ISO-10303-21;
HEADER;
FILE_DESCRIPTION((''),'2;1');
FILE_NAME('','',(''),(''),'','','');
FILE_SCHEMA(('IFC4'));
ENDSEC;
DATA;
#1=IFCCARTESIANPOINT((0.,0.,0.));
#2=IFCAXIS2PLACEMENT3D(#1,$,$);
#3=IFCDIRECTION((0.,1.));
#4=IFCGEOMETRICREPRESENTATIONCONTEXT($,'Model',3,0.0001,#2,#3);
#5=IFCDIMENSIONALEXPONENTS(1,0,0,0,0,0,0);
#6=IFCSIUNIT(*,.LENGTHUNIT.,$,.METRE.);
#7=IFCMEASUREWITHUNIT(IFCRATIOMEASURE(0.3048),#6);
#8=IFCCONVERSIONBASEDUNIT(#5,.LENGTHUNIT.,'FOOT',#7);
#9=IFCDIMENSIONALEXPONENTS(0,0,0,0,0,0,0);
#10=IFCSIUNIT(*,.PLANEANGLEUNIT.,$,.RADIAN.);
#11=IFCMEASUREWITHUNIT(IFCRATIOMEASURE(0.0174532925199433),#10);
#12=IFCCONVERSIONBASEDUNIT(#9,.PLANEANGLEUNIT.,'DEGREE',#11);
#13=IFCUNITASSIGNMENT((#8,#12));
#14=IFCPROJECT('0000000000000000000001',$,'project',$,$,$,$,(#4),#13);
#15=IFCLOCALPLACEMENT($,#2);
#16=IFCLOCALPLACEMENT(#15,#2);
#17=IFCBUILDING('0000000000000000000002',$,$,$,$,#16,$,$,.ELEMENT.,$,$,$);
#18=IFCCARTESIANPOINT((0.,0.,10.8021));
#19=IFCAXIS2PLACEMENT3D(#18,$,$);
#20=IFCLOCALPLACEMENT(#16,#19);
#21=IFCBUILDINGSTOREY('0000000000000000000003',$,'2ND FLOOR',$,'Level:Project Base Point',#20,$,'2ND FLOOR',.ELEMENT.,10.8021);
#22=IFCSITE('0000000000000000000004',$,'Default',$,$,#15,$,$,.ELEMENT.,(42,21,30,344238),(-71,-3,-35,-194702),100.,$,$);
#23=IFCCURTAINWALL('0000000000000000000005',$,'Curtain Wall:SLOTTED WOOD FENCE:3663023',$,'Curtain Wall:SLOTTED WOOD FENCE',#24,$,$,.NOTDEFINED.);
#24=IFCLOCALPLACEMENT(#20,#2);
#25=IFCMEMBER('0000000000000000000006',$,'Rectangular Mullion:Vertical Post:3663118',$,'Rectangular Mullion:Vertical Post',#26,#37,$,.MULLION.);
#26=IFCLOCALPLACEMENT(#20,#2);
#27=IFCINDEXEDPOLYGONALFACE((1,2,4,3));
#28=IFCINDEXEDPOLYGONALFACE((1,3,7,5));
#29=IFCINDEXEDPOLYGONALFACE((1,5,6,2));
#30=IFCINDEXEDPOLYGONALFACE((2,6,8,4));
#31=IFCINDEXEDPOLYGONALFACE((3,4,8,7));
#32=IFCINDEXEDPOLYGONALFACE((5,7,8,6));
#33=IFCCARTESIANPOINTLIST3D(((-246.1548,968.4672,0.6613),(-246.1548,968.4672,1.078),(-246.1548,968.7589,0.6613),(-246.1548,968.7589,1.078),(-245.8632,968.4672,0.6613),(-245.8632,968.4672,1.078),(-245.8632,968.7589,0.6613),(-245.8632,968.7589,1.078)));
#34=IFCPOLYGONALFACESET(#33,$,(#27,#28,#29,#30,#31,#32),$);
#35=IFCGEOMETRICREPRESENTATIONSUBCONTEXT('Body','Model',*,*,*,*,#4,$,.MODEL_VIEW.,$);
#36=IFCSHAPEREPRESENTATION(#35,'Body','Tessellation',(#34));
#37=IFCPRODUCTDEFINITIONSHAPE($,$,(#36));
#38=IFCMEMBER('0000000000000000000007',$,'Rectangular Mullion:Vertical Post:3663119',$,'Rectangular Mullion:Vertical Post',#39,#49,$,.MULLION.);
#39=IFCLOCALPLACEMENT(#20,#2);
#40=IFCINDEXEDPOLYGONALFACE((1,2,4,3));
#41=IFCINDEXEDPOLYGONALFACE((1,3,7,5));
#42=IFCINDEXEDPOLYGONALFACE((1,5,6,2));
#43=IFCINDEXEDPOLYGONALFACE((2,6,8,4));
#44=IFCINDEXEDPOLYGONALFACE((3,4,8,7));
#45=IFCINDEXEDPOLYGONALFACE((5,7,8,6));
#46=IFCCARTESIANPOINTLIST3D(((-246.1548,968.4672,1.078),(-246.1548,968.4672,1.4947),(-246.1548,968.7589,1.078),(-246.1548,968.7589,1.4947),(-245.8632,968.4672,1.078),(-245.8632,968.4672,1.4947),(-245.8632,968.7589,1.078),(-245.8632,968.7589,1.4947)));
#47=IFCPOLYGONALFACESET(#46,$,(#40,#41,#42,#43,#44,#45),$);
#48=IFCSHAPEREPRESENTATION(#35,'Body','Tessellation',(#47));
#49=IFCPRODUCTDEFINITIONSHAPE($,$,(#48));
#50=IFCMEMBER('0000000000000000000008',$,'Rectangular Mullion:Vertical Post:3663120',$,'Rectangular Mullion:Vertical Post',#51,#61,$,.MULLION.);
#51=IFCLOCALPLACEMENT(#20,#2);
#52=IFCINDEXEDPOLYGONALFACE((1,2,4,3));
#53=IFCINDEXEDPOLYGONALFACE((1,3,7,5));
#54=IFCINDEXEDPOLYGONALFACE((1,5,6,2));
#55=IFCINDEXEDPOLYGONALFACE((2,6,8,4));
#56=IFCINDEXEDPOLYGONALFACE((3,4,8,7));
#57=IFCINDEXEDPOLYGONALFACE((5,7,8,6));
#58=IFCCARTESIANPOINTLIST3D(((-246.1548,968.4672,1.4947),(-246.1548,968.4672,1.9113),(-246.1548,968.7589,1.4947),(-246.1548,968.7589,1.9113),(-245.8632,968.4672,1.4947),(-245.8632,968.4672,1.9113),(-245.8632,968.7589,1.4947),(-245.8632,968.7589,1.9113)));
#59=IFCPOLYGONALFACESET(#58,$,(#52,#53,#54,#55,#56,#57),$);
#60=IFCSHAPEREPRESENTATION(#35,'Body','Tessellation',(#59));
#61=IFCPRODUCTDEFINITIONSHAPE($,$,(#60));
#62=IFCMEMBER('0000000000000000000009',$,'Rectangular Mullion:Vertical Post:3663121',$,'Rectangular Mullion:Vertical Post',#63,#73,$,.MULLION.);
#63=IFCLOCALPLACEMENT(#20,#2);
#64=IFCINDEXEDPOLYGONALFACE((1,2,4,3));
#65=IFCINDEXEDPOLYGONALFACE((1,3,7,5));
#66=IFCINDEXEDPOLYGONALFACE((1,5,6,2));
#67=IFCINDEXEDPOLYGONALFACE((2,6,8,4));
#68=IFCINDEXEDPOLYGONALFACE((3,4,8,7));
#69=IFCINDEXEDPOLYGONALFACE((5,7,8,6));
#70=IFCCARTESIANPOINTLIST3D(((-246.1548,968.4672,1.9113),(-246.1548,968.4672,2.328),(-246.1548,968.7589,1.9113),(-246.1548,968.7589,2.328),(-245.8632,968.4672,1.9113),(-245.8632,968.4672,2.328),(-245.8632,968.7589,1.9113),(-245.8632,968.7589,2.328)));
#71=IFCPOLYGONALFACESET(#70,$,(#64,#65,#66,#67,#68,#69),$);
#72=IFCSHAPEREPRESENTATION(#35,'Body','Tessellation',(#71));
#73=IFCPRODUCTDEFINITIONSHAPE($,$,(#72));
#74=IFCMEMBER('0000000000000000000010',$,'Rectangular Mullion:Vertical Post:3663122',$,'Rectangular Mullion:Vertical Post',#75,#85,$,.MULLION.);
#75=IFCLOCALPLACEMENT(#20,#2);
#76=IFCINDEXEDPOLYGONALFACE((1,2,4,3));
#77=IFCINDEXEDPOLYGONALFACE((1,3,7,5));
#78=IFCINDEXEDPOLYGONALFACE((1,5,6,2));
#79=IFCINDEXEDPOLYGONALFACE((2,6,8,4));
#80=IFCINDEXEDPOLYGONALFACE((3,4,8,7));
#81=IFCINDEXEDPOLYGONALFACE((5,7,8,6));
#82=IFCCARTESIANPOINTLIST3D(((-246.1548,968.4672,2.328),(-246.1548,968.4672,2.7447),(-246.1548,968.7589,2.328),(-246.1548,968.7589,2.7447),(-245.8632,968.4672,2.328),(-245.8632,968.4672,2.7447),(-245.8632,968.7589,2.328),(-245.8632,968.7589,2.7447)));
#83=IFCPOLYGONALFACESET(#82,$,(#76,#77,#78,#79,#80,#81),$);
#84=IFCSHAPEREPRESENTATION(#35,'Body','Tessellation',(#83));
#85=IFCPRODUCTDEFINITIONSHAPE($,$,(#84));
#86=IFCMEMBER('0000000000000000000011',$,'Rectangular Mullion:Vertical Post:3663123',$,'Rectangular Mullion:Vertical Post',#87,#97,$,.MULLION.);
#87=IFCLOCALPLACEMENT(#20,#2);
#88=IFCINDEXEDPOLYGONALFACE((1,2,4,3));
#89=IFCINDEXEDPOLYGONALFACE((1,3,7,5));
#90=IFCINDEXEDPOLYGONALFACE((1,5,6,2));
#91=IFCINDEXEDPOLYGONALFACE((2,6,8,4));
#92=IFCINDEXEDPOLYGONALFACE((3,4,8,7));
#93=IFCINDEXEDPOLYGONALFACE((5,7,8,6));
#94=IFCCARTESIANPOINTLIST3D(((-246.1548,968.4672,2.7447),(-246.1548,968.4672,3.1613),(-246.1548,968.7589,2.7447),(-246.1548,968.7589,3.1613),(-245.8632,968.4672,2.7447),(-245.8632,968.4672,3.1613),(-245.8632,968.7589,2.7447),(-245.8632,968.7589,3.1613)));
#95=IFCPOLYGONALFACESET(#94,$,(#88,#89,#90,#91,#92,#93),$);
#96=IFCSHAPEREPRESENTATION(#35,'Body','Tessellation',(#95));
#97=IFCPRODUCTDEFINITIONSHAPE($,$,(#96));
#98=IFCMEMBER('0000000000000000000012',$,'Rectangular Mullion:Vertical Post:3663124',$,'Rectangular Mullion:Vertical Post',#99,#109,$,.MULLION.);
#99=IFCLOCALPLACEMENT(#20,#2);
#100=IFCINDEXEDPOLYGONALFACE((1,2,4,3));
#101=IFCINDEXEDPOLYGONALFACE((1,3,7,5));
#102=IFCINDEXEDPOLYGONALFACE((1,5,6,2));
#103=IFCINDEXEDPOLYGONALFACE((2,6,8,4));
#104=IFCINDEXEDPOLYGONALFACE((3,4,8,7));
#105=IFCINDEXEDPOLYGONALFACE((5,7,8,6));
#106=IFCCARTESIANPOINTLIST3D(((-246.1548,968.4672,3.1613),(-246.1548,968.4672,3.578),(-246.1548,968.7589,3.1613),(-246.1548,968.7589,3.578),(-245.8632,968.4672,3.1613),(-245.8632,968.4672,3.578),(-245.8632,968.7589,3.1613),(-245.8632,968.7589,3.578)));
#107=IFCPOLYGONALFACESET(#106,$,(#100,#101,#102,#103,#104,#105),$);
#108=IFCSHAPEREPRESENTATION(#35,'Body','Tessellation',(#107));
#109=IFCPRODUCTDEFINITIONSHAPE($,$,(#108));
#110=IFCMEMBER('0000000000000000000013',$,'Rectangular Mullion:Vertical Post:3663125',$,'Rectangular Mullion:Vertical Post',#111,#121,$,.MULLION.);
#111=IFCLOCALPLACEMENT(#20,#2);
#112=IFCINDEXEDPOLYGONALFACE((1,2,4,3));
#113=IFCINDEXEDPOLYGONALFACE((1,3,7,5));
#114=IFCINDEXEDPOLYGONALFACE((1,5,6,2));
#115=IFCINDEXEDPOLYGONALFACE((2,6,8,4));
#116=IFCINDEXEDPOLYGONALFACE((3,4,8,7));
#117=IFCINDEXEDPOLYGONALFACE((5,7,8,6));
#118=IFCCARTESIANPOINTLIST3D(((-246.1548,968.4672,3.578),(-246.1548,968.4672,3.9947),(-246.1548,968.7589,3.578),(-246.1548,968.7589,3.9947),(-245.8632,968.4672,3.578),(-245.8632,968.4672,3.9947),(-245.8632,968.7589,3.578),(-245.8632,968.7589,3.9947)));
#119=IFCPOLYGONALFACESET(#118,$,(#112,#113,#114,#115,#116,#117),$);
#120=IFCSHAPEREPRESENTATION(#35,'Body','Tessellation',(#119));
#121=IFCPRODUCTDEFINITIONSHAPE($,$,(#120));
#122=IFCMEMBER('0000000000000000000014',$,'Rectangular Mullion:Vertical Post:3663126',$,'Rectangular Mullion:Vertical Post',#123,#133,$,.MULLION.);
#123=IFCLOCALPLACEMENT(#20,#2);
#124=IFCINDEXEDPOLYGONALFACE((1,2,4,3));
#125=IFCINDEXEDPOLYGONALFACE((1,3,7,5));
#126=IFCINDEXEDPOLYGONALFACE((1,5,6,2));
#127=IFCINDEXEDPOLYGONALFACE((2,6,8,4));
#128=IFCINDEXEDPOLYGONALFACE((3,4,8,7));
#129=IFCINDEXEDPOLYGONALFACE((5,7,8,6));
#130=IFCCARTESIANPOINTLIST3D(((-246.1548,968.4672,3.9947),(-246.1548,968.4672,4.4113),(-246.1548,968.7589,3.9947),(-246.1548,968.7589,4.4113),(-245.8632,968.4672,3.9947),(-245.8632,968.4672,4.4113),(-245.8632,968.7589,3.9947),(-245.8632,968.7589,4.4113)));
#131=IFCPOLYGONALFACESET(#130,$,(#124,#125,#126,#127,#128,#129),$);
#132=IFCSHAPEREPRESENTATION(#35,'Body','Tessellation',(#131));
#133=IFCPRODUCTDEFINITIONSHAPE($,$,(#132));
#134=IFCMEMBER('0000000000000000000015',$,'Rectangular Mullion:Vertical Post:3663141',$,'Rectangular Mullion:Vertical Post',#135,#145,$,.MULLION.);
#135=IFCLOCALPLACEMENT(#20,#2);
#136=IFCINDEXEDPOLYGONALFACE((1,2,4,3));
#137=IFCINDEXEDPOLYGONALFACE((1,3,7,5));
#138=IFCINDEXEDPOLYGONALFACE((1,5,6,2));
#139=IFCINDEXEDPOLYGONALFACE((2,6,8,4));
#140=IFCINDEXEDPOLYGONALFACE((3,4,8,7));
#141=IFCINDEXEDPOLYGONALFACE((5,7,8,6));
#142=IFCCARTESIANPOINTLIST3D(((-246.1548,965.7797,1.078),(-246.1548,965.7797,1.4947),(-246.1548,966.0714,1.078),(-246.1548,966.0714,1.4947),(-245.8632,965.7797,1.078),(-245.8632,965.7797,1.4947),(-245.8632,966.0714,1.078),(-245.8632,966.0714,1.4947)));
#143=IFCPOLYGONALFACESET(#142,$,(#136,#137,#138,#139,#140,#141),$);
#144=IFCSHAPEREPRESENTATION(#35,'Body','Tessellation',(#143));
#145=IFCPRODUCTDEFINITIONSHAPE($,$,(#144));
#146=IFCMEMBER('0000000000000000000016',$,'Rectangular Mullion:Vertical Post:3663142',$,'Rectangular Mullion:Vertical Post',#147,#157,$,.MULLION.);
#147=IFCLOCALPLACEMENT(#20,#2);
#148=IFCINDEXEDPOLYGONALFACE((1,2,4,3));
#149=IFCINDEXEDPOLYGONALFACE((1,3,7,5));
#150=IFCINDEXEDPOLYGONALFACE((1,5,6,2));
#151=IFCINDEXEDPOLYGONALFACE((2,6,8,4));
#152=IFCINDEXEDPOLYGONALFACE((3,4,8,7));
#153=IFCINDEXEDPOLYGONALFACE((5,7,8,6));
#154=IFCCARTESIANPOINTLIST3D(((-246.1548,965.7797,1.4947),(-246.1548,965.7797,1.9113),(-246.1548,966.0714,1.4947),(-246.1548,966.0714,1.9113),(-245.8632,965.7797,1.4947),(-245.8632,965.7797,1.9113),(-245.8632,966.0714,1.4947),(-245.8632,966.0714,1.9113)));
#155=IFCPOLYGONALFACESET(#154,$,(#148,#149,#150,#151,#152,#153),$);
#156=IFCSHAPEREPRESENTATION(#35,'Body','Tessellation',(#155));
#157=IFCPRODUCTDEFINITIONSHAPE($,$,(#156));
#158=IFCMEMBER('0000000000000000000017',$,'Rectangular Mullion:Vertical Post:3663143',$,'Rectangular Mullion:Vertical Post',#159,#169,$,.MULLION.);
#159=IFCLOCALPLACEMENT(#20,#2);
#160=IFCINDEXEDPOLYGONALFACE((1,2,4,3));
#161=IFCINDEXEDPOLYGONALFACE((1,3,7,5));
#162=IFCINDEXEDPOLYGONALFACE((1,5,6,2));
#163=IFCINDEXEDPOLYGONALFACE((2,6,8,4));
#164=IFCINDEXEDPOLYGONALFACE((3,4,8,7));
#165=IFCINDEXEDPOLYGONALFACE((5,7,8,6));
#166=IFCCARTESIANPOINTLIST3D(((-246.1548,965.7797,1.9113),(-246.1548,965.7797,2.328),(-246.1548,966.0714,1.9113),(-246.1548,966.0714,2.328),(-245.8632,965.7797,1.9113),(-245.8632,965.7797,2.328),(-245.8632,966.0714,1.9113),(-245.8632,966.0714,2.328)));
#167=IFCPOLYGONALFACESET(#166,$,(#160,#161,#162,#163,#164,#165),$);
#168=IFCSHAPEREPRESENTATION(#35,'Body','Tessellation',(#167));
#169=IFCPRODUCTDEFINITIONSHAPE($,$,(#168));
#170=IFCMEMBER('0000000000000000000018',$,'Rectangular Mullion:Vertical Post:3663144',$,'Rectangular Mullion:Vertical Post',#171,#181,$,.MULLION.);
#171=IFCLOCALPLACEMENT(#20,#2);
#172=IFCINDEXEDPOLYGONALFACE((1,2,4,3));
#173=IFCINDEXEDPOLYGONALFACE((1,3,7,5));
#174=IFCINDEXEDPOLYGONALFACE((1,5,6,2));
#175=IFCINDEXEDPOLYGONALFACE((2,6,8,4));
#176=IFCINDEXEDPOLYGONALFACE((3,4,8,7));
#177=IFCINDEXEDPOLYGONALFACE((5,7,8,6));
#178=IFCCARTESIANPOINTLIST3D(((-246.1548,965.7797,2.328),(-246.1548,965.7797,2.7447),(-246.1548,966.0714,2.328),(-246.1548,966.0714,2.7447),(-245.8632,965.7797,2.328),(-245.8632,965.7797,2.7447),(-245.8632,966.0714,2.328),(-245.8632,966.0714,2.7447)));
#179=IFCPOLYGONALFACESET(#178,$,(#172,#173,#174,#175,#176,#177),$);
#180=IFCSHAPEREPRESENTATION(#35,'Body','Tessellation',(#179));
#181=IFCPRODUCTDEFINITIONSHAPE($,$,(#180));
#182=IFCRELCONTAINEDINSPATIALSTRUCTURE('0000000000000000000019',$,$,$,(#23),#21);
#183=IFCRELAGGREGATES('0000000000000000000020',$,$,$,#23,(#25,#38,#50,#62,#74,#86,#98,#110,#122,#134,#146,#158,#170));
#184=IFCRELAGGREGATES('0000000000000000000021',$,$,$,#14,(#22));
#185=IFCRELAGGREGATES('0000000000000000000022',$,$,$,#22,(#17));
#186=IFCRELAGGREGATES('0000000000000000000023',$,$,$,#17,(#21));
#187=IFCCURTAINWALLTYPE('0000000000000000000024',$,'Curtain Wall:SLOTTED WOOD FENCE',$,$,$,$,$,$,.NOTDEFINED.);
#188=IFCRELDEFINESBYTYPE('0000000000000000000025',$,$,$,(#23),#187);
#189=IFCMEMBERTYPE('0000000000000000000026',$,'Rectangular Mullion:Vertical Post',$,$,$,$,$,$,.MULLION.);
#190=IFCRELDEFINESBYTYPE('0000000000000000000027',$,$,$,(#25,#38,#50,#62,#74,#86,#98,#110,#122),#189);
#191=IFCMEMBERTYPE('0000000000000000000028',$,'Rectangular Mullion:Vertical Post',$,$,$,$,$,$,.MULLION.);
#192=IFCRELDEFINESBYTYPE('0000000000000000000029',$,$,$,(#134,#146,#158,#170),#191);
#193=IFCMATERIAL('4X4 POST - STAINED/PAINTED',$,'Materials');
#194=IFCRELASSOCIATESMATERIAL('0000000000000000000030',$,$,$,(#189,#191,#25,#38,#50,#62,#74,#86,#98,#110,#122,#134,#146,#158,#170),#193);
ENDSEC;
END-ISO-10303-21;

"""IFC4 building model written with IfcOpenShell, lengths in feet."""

from ifc_helpers import new_model, entity, si_unit, converted_unit, direction, frame, origin, origin_2d_with_axis, place, context, subcontext, project, spatial, rectangle, extrude, source, transform, mapped, material, material_profile, profile_set, profile_usage, type_object, type_shapes, element, aggregate, save


model = new_model("IFC4")

# Units and contexts
model_context = context("Model", 3, precision=0.0001, world=origin(), true_north=direction((0.0, 1.0)))
body_context = subcontext(model_context, "Body", "Model", "MODEL_VIEW")
ifc_project = project(units=[converted_unit("LENGTHUNIT", "FOOT", entity("IfcRatioMeasure", 0.3048), si_unit("LENGTHUNIT", "METRE"), dimensions=[1, 0, 0, 0, 0, 0, 0]), converted_unit("PLANEANGLEUNIT", "DEGREE", entity("IfcRatioMeasure", 0.0174532925199433), si_unit("PLANEANGLEUNIT", "RADIAN"), dimensions=[0, 0, 0, 0, 0, 0, 0])], contexts=[model_context])

# Site, building, storey
site_placement = place(None, origin())
site = spatial("IfcSite", under=ifc_project, at=site_placement, Name="Default", CompositionType="ELEMENT", RefLatitude=(42, 21, 30, 344238), RefLongitude=(-71, -3, -35, -194702), RefElevation=100.0)
building_placement = place(site_placement, origin())
building = spatial("IfcBuilding", under=site, at=building_placement, CompositionType="ELEMENT")
storey_placement = place(building_placement, frame((0.0, 0.0, 10.8021)))
storey = spatial("IfcBuildingStorey", under=building, at=storey_placement, Name="2ND FLOOR", ObjectType="Level:Project Base Point", LongName="2ND FLOOR", CompositionType="ELEMENT", Elevation=10.8021)

# Curtain wall, members
curtain_wall_type_1 = type_object("IfcCurtainWallType", Name="Curtain Wall:SLOTTED WOOD FENCE", PredefinedType="NOTDEFINED")
curtain_wall_1_placement = place(storey_placement, frame((0.0, 0.0, -10.8021)))
curtain_wall_1 = element("IfcCurtainWall", 1, at=curtain_wall_1_placement, inside=storey, type_object=curtain_wall_type_1, Name="Curtain Wall:SLOTTED WOOD FENCE:3663023", ObjectType="Curtain Wall:SLOTTED WOOD FENCE", PredefinedType="NOTDEFINED")
ifc_material_1 = material(Name="4X4 POST - STAINED/PAINTED", Category="Materials")
ifc_material_profile_1 = material_profile(ifc_material_1, rectangle(XDim=0.2917, YDim=0.2917, at=origin_2d_with_axis()), Name="Vertical Post")
ifc_profile_set_1 = profile_set([ifc_material_profile_1], Name="Vertical Post")
ifc_profile_usage_1 = profile_usage(ifc_profile_set_1)
member_type_1 = type_object("IfcMemberType", Name="Rectangular Mullion:Vertical Post", PredefinedType="MULLION", material=ifc_profile_set_1)
shared_shape_1 = source(origin(), body_context, "Body", "SweptSolid", [
    extrude(rectangle(XDim=0.2917, YDim=0.2917, at=origin_2d_with_axis()), frame((-0.1458, 0.2083, -0.4167), z_axis=(0.0, 0.0, 1.0), x_axis=(0.0, -1.0, 0.0)), (0.0, 0.0, 1.0), 0.4167),
])
type_shapes(member_type_1, [shared_shape_1])
member_1_placement = place(storey_placement, frame((-245.8007, 968.7589, 1.078), z_axis=(0.0, 0.0, 1.0), x_axis=(0.0, 1.0, 0.0)))
member_1 = element("IfcMember", 2, at=member_1_placement, type_object=member_type_1, material=ifc_profile_usage_1, Name="Rectangular Mullion:Vertical Post:3663118", ObjectType="Rectangular Mullion:Vertical Post", PredefinedType="MULLION", context=body_context, shape_type="MappedRepresentation", body=[
    mapped(shared_shape_1, transform((0.0, 0.0, 0.0), scale=1.0)),
])
ifc_profile_usage_2 = profile_usage(ifc_profile_set_1)
member_2_placement = place(storey_placement, frame((-245.8007, 968.7589, 1.4947), z_axis=(0.0, 0.0, 1.0), x_axis=(0.0, 1.0, 0.0)))
member_2 = element("IfcMember", 3, at=member_2_placement, type_object=member_type_1, material=ifc_profile_usage_2, Name="Rectangular Mullion:Vertical Post:3663119", ObjectType="Rectangular Mullion:Vertical Post", PredefinedType="MULLION", context=body_context, shape_type="MappedRepresentation", body=[
    mapped(shared_shape_1, transform((0.0, 0.0, 0.0), scale=1.0)),
])
ifc_profile_usage_3 = profile_usage(ifc_profile_set_1)
member_3_placement = place(storey_placement, frame((-245.8007, 968.7589, 1.9113), z_axis=(0.0, 0.0, 1.0), x_axis=(0.0, 1.0, 0.0)))
member_3 = element("IfcMember", 4, at=member_3_placement, type_object=member_type_1, material=ifc_profile_usage_3, Name="Rectangular Mullion:Vertical Post:3663120", ObjectType="Rectangular Mullion:Vertical Post", PredefinedType="MULLION", context=body_context, shape_type="MappedRepresentation", body=[
    mapped(shared_shape_1, transform((0.0, 0.0, 0.0), scale=1.0)),
])
ifc_profile_usage_4 = profile_usage(ifc_profile_set_1)
member_4_placement = place(storey_placement, frame((-245.8007, 968.7589, 2.328), z_axis=(0.0, 0.0, 1.0), x_axis=(0.0, 1.0, 0.0)))
member_4 = element("IfcMember", 5, at=member_4_placement, type_object=member_type_1, material=ifc_profile_usage_4, Name="Rectangular Mullion:Vertical Post:3663121", ObjectType="Rectangular Mullion:Vertical Post", PredefinedType="MULLION", context=body_context, shape_type="MappedRepresentation", body=[
    mapped(shared_shape_1, transform((0.0, 0.0, 0.0), scale=1.0)),
])
ifc_profile_usage_5 = profile_usage(ifc_profile_set_1)
member_5_placement = place(storey_placement, frame((-245.8007, 968.7589, 2.7447), z_axis=(0.0, 0.0, 1.0), x_axis=(0.0, 1.0, 0.0)))
member_5 = element("IfcMember", 6, at=member_5_placement, type_object=member_type_1, material=ifc_profile_usage_5, Name="Rectangular Mullion:Vertical Post:3663122", ObjectType="Rectangular Mullion:Vertical Post", PredefinedType="MULLION", context=body_context, shape_type="MappedRepresentation", body=[
    mapped(shared_shape_1, transform((0.0, 0.0, 0.0), scale=1.0)),
])
ifc_profile_usage_6 = profile_usage(ifc_profile_set_1)
member_6_placement = place(storey_placement, frame((-245.8007, 968.7589, 3.1613), z_axis=(0.0, 0.0, 1.0), x_axis=(0.0, 1.0, 0.0)))
member_6 = element("IfcMember", 7, at=member_6_placement, type_object=member_type_1, material=ifc_profile_usage_6, Name="Rectangular Mullion:Vertical Post:3663123", ObjectType="Rectangular Mullion:Vertical Post", PredefinedType="MULLION", context=body_context, shape_type="MappedRepresentation", body=[
    mapped(shared_shape_1, transform((0.0, 0.0, 0.0), scale=1.0)),
])
ifc_profile_usage_7 = profile_usage(ifc_profile_set_1)
member_7_placement = place(storey_placement, frame((-245.8007, 968.7589, 3.578), z_axis=(0.0, 0.0, 1.0), x_axis=(0.0, 1.0, 0.0)))
member_7 = element("IfcMember", 8, at=member_7_placement, type_object=member_type_1, material=ifc_profile_usage_7, Name="Rectangular Mullion:Vertical Post:3663124", ObjectType="Rectangular Mullion:Vertical Post", PredefinedType="MULLION", context=body_context, shape_type="MappedRepresentation", body=[
    mapped(shared_shape_1, transform((0.0, 0.0, 0.0), scale=1.0)),
])
ifc_profile_usage_8 = profile_usage(ifc_profile_set_1)
member_8_placement = place(storey_placement, frame((-245.8007, 968.7589, 3.9947), z_axis=(0.0, 0.0, 1.0), x_axis=(0.0, 1.0, 0.0)))
member_8 = element("IfcMember", 9, at=member_8_placement, type_object=member_type_1, material=ifc_profile_usage_8, Name="Rectangular Mullion:Vertical Post:3663125", ObjectType="Rectangular Mullion:Vertical Post", PredefinedType="MULLION", context=body_context, shape_type="MappedRepresentation", body=[
    mapped(shared_shape_1, transform((0.0, 0.0, 0.0), scale=1.0)),
])
ifc_profile_usage_9 = profile_usage(ifc_profile_set_1)
member_9_placement = place(storey_placement, frame((-245.8007, 968.7589, 4.4113), z_axis=(0.0, 0.0, 1.0), x_axis=(0.0, 1.0, 0.0)))
member_9 = element("IfcMember", 10, at=member_9_placement, type_object=member_type_1, material=ifc_profile_usage_9, Name="Rectangular Mullion:Vertical Post:3663126", ObjectType="Rectangular Mullion:Vertical Post", PredefinedType="MULLION", context=body_context, shape_type="MappedRepresentation", body=[
    mapped(shared_shape_1, transform((0.0, 0.0, 0.0), scale=1.0)),
])
ifc_profile_usage_10 = profile_usage(ifc_profile_set_1)
member_type_2 = type_object("IfcMemberType", Name="Rectangular Mullion:Vertical Post", PredefinedType="MULLION", material=ifc_profile_set_1)
shared_shape_2 = source(origin(), body_context, "Body", "SweptSolid", [
    extrude(rectangle(XDim=0.2917, YDim=0.2917, at=origin_2d_with_axis()), frame((0.0, 0.2083, -0.4167), z_axis=(0.0, 0.0, 1.0), x_axis=(0.0, -1.0, 0.0)), (0.0, 0.0, 1.0), 0.4167),
])
type_shapes(member_type_2, [shared_shape_2])
member_10_placement = place(storey_placement, frame((-245.8007, 965.9255, 1.078), z_axis=(0.0, 0.0, -1.0), x_axis=(0.0, -1.0, 0.0)))
member_10 = element("IfcMember", 11, at=member_10_placement, type_object=member_type_2, material=ifc_profile_usage_10, Name="Rectangular Mullion:Vertical Post:3663141", ObjectType="Rectangular Mullion:Vertical Post", PredefinedType="MULLION", context=body_context, shape_type="MappedRepresentation", body=[
    mapped(shared_shape_2, transform((0.0, 0.0, 0.0), scale=1.0)),
])
ifc_profile_usage_11 = profile_usage(ifc_profile_set_1)
member_11_placement = place(storey_placement, frame((-245.8007, 965.9255, 1.4947), z_axis=(0.0, 0.0, -1.0), x_axis=(0.0, -1.0, 0.0)))
member_11 = element("IfcMember", 12, at=member_11_placement, type_object=member_type_2, material=ifc_profile_usage_11, Name="Rectangular Mullion:Vertical Post:3663142", ObjectType="Rectangular Mullion:Vertical Post", PredefinedType="MULLION", context=body_context, shape_type="MappedRepresentation", body=[
    mapped(shared_shape_2, transform((0.0, 0.0, 0.0), scale=1.0)),
])
ifc_profile_usage_12 = profile_usage(ifc_profile_set_1)
member_12_placement = place(storey_placement, frame((-245.8007, 965.9255, 1.9113), z_axis=(0.0, 0.0, -1.0), x_axis=(0.0, -1.0, 0.0)))
member_12 = element("IfcMember", 13, at=member_12_placement, type_object=member_type_2, material=ifc_profile_usage_12, Name="Rectangular Mullion:Vertical Post:3663143", ObjectType="Rectangular Mullion:Vertical Post", PredefinedType="MULLION", context=body_context, shape_type="MappedRepresentation", body=[
    mapped(shared_shape_2, transform((0.0, 0.0, 0.0), scale=1.0)),
])
ifc_profile_usage_13 = profile_usage(ifc_profile_set_1)
member_13_placement = place(storey_placement, frame((-245.8007, 965.9255, 2.328), z_axis=(0.0, 0.0, -1.0), x_axis=(0.0, -1.0, 0.0)))
member_13 = element("IfcMember", 14, at=member_13_placement, type_object=member_type_2, material=ifc_profile_usage_13, Name="Rectangular Mullion:Vertical Post:3663144", ObjectType="Rectangular Mullion:Vertical Post", PredefinedType="MULLION", context=body_context, shape_type="MappedRepresentation", body=[
    mapped(shared_shape_2, transform((0.0, 0.0, 0.0), scale=1.0)),
])
aggregate(curtain_wall_1, [member_1, member_2, member_3, member_4, member_5, member_6, member_7, member_8, member_9, member_10, member_11, member_12, member_13])

save(model, "model.ifc")
